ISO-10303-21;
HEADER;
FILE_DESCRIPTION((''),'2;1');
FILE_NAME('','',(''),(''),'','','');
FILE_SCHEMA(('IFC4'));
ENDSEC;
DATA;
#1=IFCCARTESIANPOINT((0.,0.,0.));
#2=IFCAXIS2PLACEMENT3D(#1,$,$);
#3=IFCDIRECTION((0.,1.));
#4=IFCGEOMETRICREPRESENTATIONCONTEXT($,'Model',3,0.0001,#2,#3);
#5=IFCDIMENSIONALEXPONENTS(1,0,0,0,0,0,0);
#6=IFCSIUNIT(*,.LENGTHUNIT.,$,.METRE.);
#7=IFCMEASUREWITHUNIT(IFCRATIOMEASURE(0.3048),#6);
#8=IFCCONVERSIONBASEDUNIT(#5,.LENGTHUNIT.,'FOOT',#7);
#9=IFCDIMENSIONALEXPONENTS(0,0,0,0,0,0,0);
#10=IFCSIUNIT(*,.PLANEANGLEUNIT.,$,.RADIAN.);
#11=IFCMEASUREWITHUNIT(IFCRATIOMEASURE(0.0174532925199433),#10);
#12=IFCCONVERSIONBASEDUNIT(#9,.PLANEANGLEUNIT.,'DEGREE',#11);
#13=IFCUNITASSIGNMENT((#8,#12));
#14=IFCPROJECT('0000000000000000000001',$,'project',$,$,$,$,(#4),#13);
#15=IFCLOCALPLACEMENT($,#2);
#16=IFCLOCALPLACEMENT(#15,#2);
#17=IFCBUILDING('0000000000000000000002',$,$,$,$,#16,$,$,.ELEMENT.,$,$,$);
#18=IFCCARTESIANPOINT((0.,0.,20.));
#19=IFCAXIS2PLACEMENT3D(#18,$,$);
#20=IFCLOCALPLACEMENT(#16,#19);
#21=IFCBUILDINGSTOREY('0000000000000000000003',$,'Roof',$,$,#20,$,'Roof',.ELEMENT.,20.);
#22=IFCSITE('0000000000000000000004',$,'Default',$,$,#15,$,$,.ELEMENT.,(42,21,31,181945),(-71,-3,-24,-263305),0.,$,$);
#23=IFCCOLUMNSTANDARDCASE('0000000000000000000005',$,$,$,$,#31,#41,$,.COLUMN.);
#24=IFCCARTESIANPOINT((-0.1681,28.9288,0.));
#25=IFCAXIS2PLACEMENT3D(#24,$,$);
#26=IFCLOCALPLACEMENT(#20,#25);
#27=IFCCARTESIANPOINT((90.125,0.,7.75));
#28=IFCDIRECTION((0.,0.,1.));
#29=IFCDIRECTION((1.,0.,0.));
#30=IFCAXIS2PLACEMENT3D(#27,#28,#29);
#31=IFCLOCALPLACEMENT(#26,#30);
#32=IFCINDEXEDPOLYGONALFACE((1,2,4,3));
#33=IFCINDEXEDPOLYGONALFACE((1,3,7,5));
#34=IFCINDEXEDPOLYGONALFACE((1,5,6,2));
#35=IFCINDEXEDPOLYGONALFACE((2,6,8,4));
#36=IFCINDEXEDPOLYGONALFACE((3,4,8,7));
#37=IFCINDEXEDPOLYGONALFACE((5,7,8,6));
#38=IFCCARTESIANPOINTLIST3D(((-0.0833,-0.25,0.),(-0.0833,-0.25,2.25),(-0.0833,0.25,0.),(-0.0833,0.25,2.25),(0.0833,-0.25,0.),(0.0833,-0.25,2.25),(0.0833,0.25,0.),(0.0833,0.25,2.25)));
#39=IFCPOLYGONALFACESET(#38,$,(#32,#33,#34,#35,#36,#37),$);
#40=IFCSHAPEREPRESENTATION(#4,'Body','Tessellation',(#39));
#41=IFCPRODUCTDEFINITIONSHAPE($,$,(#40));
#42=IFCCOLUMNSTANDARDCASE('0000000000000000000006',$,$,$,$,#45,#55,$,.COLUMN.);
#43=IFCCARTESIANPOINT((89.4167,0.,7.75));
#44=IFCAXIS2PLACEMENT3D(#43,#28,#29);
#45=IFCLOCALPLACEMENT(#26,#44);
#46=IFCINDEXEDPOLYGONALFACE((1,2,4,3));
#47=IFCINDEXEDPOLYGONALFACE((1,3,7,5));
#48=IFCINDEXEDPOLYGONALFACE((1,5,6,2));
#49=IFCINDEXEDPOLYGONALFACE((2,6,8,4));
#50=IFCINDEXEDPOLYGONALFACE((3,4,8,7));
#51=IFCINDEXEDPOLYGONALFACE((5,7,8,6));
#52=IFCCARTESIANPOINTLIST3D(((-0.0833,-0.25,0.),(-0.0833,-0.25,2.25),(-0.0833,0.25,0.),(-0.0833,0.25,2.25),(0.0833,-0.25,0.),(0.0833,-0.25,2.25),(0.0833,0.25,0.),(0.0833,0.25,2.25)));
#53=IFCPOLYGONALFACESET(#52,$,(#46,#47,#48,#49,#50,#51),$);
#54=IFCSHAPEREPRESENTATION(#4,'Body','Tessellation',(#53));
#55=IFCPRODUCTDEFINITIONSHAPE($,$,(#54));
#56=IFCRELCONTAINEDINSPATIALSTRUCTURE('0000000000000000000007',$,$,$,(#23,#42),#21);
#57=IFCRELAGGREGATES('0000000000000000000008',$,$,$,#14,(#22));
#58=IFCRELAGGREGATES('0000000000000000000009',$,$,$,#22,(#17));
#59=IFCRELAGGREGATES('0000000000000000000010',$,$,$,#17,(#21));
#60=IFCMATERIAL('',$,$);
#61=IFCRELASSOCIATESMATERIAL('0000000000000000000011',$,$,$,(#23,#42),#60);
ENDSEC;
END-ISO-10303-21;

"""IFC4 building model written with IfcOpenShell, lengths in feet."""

from ifc_helpers import new_model, entity, si_unit, converted_unit, direction, frame, origin, place, context, project, spatial, rectangle, extrude, material, element, save


model = new_model("IFC4")

# Units and contexts
model_context = context("Model", 3, precision=0.0001, world=origin(), true_north=direction((0.0, 1.0)))
ifc_project = project(units=[converted_unit("LENGTHUNIT", "FOOT", entity("IfcRatioMeasure", 0.3048), si_unit("LENGTHUNIT", "METRE"), dimensions=[1, 0, 0, 0, 0, 0, 0]), converted_unit("PLANEANGLEUNIT", "DEGREE", entity("IfcRatioMeasure", 0.0174532925199433), si_unit("PLANEANGLEUNIT", "RADIAN"), dimensions=[0, 0, 0, 0, 0, 0, 0])], contexts=[model_context])

# Site, building, storey
site_placement = place(None, origin())
site = spatial("IfcSite", under=ifc_project, at=site_placement, Name="Default", CompositionType="ELEMENT", RefLatitude=(42, 21, 31, 181945), RefLongitude=(-71, -3, -24, -263305), RefElevation=0.0)
building_placement = place(site_placement, origin())
building = spatial("IfcBuilding", under=site, at=building_placement, CompositionType="ELEMENT")
storey_placement = place(building_placement, frame((0.0, 0.0, 20.0)))
storey = spatial("IfcBuildingStorey", under=building, at=storey_placement, Name="Roof", LongName="Roof", CompositionType="ELEMENT", Elevation=20.0)

# Columns
ifc_material_1 = material(Name="")
placement = place(storey_placement, frame((-0.1681, 28.9288, 0.0)))
for number, where, z_axis, x_axis in (
    (1, (90.125, 0.0, 7.75), (0.0, 0.0, 1.0), (1.0, 0.0, 0.0)),
    (2, (89.4167, 0.0, 7.75), (0.0, 0.0, 1.0), (1.0, 0.0, 0.0)),
):
    element("IfcColumnStandardCase", number, at=place(placement, frame(where, z_axis=z_axis, x_axis=x_axis)), inside=storey, material=ifc_material_1, PredefinedType="COLUMN", context=model_context, shape_type="SweptSolid", body=[
        extrude(rectangle(XDim=0.1667, YDim=0.5), origin(), (0.0, 0.0, 1.0), 2.25),
    ])

save(model, "model.ifc")
